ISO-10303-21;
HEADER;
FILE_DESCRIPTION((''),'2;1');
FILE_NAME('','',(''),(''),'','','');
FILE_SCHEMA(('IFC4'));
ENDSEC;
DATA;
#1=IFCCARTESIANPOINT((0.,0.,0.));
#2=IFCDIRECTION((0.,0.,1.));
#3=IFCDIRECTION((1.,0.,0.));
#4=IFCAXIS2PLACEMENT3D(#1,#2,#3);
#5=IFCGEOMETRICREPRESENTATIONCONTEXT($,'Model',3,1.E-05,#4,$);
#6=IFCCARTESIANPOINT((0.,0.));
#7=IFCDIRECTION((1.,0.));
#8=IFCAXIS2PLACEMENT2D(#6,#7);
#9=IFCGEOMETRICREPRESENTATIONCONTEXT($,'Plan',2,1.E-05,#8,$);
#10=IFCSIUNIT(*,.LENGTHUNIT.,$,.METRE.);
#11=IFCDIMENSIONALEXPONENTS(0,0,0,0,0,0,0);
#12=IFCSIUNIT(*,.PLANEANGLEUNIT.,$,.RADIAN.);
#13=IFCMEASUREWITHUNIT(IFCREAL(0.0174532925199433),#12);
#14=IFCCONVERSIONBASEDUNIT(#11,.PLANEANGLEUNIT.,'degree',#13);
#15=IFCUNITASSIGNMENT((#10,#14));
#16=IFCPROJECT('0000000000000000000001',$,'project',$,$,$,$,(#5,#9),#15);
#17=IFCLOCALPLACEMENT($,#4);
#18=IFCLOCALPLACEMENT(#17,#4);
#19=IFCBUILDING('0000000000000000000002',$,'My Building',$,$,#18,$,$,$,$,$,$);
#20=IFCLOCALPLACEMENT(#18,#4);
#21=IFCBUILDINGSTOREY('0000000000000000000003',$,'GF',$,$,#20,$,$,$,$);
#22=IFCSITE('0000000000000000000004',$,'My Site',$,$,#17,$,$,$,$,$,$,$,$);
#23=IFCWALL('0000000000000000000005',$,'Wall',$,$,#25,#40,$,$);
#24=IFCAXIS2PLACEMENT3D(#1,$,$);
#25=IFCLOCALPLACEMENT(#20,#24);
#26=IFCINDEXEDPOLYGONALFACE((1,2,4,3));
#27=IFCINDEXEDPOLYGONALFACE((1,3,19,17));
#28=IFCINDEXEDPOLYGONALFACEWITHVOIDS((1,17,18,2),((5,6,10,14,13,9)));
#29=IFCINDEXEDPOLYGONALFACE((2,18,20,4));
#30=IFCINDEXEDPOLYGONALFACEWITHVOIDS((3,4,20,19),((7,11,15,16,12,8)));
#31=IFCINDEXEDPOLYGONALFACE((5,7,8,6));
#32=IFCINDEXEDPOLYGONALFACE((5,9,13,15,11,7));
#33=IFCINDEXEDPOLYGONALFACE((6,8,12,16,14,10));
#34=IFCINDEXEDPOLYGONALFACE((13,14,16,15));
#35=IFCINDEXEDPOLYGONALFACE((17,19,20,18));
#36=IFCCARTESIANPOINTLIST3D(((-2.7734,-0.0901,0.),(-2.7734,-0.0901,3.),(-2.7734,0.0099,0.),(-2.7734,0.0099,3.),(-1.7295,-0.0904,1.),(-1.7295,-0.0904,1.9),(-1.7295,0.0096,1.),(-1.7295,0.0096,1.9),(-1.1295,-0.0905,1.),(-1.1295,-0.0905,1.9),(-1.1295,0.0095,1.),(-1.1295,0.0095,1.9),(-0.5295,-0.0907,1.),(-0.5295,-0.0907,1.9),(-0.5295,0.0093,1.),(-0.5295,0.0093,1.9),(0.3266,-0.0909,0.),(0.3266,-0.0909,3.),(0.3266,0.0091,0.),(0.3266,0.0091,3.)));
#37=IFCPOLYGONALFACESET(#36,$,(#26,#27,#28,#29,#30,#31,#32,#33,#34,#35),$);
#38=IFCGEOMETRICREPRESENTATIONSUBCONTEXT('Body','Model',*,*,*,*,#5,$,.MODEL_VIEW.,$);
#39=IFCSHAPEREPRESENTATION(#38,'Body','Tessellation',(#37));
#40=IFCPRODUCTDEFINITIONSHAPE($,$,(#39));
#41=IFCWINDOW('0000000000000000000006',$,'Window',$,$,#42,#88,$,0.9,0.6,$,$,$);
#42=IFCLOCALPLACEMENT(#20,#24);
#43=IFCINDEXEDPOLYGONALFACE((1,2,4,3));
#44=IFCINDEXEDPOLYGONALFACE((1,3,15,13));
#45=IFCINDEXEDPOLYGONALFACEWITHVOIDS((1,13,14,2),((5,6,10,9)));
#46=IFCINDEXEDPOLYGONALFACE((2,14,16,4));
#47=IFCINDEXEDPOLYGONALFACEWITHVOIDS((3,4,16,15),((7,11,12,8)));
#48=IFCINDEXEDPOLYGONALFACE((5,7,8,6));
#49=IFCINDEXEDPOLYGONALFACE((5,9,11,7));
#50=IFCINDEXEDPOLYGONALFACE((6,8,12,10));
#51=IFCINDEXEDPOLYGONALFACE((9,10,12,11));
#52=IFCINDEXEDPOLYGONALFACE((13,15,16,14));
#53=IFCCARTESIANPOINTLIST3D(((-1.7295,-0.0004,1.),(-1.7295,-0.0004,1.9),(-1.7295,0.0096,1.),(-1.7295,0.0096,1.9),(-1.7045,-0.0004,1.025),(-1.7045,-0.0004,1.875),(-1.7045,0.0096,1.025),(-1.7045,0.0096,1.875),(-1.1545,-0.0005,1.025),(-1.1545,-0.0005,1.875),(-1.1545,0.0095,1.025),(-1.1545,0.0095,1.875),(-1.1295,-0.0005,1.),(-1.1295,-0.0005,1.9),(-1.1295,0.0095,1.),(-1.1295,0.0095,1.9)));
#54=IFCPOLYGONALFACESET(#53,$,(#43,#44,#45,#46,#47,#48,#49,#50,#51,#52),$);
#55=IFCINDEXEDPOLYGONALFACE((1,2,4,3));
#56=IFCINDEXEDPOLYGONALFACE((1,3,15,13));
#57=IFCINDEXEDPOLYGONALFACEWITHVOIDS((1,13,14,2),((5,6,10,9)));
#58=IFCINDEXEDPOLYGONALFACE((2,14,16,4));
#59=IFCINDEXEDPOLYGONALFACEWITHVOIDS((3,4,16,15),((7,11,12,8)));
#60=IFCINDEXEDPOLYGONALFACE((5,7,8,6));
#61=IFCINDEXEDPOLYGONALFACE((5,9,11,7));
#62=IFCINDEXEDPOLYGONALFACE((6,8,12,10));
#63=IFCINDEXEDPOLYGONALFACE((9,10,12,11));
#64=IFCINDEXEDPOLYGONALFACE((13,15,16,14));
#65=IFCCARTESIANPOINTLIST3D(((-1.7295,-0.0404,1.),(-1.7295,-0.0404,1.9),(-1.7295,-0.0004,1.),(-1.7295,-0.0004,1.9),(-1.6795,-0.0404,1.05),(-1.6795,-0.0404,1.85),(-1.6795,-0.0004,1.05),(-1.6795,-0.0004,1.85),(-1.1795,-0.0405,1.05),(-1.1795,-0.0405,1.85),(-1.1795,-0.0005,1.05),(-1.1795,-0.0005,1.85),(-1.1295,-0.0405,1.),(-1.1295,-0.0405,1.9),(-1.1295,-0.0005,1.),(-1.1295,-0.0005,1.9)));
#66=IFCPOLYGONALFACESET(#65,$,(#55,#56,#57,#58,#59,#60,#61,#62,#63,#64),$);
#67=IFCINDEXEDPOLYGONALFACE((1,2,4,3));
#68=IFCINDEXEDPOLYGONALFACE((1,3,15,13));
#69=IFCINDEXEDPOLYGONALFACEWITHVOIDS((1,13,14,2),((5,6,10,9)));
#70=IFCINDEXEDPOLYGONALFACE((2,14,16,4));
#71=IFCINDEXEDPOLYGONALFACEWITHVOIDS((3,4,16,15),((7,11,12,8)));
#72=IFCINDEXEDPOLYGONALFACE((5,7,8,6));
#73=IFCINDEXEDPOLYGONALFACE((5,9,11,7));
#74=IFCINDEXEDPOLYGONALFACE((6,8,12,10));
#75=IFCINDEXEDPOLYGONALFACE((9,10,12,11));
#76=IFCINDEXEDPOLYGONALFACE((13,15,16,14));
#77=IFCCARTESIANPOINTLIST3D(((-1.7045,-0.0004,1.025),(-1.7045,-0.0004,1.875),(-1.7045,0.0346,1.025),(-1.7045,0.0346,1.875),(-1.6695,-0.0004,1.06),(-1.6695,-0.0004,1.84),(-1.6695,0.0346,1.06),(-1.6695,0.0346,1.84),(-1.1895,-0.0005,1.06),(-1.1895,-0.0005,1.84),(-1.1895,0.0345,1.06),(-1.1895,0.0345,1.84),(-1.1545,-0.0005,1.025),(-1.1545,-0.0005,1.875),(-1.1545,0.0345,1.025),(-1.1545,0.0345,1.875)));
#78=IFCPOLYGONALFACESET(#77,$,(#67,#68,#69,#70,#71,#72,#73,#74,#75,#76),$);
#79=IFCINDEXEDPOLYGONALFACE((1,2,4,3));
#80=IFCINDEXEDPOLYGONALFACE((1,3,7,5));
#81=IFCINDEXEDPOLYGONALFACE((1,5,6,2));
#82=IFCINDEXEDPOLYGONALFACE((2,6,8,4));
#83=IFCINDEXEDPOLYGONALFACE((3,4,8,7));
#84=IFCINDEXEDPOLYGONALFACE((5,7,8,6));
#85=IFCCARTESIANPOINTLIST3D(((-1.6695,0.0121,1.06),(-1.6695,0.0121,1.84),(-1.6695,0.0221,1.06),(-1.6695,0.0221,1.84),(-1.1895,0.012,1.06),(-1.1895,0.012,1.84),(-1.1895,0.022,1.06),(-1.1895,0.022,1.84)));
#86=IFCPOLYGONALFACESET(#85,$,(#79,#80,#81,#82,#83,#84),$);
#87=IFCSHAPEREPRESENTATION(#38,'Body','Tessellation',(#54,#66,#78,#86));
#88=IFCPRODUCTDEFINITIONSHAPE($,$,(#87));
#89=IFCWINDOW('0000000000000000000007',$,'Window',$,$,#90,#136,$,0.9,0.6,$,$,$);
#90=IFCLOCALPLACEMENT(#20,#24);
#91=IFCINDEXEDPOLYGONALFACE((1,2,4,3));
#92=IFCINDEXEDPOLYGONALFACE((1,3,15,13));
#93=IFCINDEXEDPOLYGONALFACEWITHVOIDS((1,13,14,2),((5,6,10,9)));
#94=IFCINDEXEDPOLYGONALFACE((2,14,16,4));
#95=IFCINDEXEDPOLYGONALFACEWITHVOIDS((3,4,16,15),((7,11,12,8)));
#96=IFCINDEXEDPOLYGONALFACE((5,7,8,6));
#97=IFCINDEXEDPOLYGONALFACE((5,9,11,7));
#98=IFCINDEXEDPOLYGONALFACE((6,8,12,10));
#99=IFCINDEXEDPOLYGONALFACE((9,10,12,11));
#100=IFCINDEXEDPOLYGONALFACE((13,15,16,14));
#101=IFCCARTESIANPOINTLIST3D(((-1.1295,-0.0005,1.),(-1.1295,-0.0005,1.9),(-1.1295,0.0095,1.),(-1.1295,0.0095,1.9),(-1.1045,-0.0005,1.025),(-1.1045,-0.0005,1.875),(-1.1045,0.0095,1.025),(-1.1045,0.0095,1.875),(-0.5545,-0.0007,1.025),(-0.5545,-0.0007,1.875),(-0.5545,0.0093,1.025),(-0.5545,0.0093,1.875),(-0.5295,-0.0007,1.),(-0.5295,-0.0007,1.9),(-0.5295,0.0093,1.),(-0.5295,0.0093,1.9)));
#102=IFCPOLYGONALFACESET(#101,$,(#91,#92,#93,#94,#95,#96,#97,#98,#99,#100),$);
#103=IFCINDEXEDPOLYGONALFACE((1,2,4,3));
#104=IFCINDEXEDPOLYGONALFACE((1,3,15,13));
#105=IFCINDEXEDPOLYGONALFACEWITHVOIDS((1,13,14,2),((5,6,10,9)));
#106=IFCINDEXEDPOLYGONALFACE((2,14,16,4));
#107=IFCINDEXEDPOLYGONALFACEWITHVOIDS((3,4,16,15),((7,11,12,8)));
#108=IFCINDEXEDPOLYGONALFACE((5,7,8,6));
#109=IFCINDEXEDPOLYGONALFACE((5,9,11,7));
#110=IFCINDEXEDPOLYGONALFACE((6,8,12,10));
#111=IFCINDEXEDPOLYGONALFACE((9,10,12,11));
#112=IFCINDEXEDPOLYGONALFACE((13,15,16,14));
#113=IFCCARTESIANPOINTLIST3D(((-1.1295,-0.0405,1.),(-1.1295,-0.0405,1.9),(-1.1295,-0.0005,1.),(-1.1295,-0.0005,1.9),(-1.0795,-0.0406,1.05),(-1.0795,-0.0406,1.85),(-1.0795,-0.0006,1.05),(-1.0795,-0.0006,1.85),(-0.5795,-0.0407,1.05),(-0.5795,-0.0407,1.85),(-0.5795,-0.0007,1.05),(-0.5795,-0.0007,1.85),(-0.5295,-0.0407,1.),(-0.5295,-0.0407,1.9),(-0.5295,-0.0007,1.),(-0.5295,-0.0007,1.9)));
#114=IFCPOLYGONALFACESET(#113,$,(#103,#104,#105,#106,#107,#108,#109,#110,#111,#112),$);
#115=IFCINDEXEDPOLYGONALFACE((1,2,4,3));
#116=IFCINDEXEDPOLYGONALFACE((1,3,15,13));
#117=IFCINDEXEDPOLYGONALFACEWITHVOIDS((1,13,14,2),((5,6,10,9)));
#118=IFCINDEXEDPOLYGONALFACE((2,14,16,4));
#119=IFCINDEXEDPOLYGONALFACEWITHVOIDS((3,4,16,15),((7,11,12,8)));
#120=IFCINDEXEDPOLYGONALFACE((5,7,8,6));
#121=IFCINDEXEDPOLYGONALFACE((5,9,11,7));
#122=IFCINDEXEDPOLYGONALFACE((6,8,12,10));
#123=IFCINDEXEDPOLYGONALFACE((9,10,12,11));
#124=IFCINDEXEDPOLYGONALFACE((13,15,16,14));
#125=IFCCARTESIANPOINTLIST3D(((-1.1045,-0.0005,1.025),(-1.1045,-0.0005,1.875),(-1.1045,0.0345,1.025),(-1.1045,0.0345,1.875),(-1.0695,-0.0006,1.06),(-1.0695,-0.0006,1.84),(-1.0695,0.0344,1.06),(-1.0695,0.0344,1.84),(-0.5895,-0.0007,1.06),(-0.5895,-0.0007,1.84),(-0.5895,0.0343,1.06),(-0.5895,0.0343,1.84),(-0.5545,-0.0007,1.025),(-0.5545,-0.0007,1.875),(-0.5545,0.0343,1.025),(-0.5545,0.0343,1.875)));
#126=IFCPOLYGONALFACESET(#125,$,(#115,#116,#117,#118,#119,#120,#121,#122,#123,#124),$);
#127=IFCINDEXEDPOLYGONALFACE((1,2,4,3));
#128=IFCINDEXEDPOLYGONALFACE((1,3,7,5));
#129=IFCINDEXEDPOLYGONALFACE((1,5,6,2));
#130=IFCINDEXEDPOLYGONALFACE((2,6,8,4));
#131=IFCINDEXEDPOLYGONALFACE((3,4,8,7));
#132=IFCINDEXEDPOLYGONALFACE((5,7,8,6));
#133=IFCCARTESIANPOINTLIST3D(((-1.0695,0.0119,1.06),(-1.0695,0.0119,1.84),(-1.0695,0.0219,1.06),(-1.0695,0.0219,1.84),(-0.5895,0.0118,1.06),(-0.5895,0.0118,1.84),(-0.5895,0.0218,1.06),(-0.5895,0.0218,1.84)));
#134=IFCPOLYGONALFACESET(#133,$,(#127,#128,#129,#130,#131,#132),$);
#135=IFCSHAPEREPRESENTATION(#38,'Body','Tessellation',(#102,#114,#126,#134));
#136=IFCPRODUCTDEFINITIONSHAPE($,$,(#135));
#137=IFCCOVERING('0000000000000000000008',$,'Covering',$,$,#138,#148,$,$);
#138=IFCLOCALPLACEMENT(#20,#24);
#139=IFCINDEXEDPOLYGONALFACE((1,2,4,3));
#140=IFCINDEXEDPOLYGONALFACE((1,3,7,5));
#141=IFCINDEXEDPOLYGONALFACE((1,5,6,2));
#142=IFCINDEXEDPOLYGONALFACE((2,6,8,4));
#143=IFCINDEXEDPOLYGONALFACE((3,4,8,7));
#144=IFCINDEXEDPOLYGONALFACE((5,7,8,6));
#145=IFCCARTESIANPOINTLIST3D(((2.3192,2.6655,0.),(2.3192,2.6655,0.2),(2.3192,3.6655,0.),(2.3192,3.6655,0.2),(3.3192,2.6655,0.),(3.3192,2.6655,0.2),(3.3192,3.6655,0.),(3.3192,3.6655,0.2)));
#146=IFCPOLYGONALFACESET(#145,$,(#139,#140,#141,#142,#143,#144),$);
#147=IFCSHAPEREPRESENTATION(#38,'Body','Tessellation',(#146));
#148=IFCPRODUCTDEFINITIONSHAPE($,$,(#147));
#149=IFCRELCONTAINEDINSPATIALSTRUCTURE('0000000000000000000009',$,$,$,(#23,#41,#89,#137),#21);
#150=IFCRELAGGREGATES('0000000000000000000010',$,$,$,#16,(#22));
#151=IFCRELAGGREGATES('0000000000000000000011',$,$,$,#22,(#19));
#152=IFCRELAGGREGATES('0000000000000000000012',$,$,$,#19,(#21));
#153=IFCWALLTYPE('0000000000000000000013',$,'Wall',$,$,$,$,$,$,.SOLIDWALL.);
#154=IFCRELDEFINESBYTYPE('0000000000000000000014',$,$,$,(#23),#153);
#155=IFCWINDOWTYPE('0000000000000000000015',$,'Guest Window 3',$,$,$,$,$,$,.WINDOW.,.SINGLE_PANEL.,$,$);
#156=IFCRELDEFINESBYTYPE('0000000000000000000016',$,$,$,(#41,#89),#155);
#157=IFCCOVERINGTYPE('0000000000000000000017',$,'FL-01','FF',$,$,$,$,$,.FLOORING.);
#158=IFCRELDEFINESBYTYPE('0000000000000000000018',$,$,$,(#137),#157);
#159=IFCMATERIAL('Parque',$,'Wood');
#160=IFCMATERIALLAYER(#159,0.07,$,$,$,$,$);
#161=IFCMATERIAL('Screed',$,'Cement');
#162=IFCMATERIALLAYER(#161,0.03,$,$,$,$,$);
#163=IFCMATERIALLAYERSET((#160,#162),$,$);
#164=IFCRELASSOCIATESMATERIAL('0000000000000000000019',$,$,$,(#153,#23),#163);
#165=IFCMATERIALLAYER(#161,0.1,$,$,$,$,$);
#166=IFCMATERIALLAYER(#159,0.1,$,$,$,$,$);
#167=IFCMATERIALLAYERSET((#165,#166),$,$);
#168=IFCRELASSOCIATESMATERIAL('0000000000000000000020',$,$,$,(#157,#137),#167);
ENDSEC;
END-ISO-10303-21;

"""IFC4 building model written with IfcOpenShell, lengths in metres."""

from ifc_helpers import new_model, entity, si_unit, converted_unit, frame, origin_with_axes, origin_2d_with_axis, place, context, subcontext, project, spatial, line, indexed_curve, outline, extrude, shape, source, transform, mapped, material, layer, layer_set, layer_usage, type_object, type_shapes, element, fill, save


model = new_model("IFC4")

# Units and contexts
model_context = context("Model", 3, precision=1e-05, world=origin_with_axes())
plan_context = context("Plan", 2, precision=1e-05, world=origin_2d_with_axis())
body_context_1 = subcontext(model_context, "Body", "Model", "MODEL_VIEW")
body_context_2 = subcontext(plan_context, "Body", "Plan", "PLAN_VIEW")
ifc_project = project(units=[si_unit("LENGTHUNIT", "METRE"), converted_unit("PLANEANGLEUNIT", "degree", entity("IfcReal", 0.0174532925199433), si_unit("PLANEANGLEUNIT", "RADIAN"), dimensions=[0, 0, 0, 0, 0, 0, 0])], contexts=[model_context, plan_context])

# Site, building, storey
site_placement = place(None, origin_with_axes())
site = spatial("IfcSite", under=ifc_project, at=site_placement, Name="My Site")
building_placement = place(site_placement, origin_with_axes())
building = spatial("IfcBuilding", under=site, at=building_placement, Name="My Building")
storey_placement = place(building_placement, origin_with_axes())
storey = spatial("IfcBuildingStorey", under=building, at=storey_placement, Name="GF")

# Shared definitions
ifc_material_1 = material(Name="Parque", Category="Wood")
ifc_layer_1 = layer(ifc_material_1, 0.07)
ifc_material_2 = material(Name="Screed", Category="Cement")
ifc_layer_2 = layer(ifc_material_2, 0.03)
ifc_layer_set_1 = layer_set([ifc_layer_1, ifc_layer_2])
wall_type = type_object("IfcWallType", Name="Wall", PredefinedType="SOLIDWALL", material=ifc_layer_set_1)

# Wall, openings, windows
ifc_layer_usage_1 = layer_usage(ifc_layer_set_1, "AXIS2", "POSITIVE", 0.0)
wall_1_placement = place(storey_placement, frame((-2.7734, -0.0901, 0.0), z_axis=(0.0, 0.0, 1.0), x_axis=(1.0, -0.000264, 0.0)))
wall_1 = element("IfcWall", 1, at=wall_1_placement, inside=storey, type_object=wall_type, material=ifc_layer_usage_1, Name="Wall", context=body_context_1, shape_type="SweptSolid", body=[
    extrude(outline(indexed_curve([(0.0, 0.0), (0.0, 0.1), (3.1, 0.1), (3.1, 0.0)], segments=[line(1, 2, 3, 4, 1)])), origin_with_axes(), (0.0, 0.0, 1.0), 3.0),
])
shared_shape_1 = source(origin_with_axes(), body_context_1, "Body", "SweptSolid", [
    extrude(outline(indexed_curve([(0.0, 0.0), (0.6, 0.0), (0.6, 0.9), (0.0, 0.9)], segments=[line(1, 2, 3, 4, 1)])), frame((0.0, -0.6, 0.0), z_axis=(0.0, -1.0, 0.0), x_axis=(1.0, 0.0, 0.0)), (0.0, 0.0, -1.0), 1.2),
])
opening_1_placement = place(wall_1_placement, frame((1.0439, 0.0, 1.0), z_axis=(0.0, 0.0, 1.0), x_axis=(1.0, 0.0, 0.0)))
opening_1 = element("IfcOpeningElement", 2, at=opening_1_placement, cuts=wall_1, PredefinedType="OPENING", context=body_context_1, shape_type="MappedRepresentation", body=[
    mapped(shared_shape_1, transform((0.0, 0.0, 0.0), x_axis=(1.0, 0.0, 0.0), y_axis=(0.0, 1.0, 0.0), z_axis=(0.0, 0.0, 1.0), scale=1.0)),
])
opening_2_placement = place(wall_1_placement, frame((1.6439, 0.0, 1.0), z_axis=(0.0, 0.0, 1.0), x_axis=(1.0, 0.0, 0.0)))
opening_2 = element("IfcOpeningElement", 3, at=opening_2_placement, cuts=wall_1, PredefinedType="OPENING", context=body_context_1, shape_type="MappedRepresentation", body=[
    mapped(shared_shape_1, transform((0.0, 0.0, 0.0), x_axis=(1.0, 0.0, 0.0), y_axis=(0.0, 1.0, 0.0), z_axis=(0.0, 0.0, 1.0), scale=1.0)),
])
window_type_1 = type_object("IfcWindowType", Name="Guest Window 3", PartitioningType="SINGLE_PANEL", PredefinedType="WINDOW")
shared_shape_2 = source(origin_with_axes(), body_context_1, "Body", "SweptSolid", [
    extrude(outline(indexed_curve([(0.0, 0.0), (0.6, 0.0), (0.6, 0.9), (0.0, 0.9)], segments=[line(1, 2, 3, 4, 1)]), holes=[indexed_curve([(0.025, 0.025), (0.575, 0.025), (0.575, 0.875), (0.025, 0.875)], segments=[line(1, 2, 3, 4, 1)])]), frame((0.0, 0.09, 0.0), z_axis=(0.0, -1.0, 0.0), x_axis=(1.0, 0.0, 0.0)), (0.0, 0.0, -1.0), 0.01),
    extrude(outline(indexed_curve([(0.0, 0.0), (0.6, 0.0), (0.6, 0.9), (0.0, 0.9)], segments=[line(1, 2, 3, 4, 1)]), holes=[indexed_curve([(0.05, 0.05), (0.55, 0.05), (0.55, 0.85), (0.05, 0.85)], segments=[line(1, 2, 3, 4, 1)])]), frame((0.0, 0.05, 0.0), z_axis=(0.0, -1.0, 0.0), x_axis=(1.0, 0.0, 0.0)), (0.0, 0.0, -1.0), 0.04),
    extrude(outline(indexed_curve([(0.0, 0.0), (0.55, 0.0), (0.55, 0.85), (0.0, 0.85)], segments=[line(1, 2, 3, 4, 1)]), holes=[indexed_curve([(0.035, 0.035), (0.515, 0.035), (0.515, 0.815), (0.035, 0.815)], segments=[line(1, 2, 3, 4, 1)])]), frame((0.025, 0.09, 0.025), z_axis=(0.0, -1.0, 0.0), x_axis=(1.0, 0.0, 0.0)), (0.0, 0.0, -1.0), 0.035),
    extrude(outline(indexed_curve([(0.035, 0.035), (0.515, 0.035), (0.515, 0.815), (0.035, 0.815)], segments=[line(1, 2, 3, 4, 1)])), frame((0.025, 0.1025, 0.025), z_axis=(0.0, -1.0, 0.0), x_axis=(1.0, 0.0, 0.0)), (0.0, 0.0, -1.0), 0.01),
])
shared_shape_3 = source(origin_with_axes(), body_context_2, "Body", "Curve2D", [
    entity("IfcIndexedPolyCurve", entity("IfcCartesianPointList2D", [[0.05, 0.05], [0.55, 0.05]])),
    entity("IfcIndexedPolyCurve", entity("IfcCartesianPointList2D", [[0.0, 0.1], [0.025, 0.1], [0.025, 0.09], [0.05, 0.09], [0.05, 0.05], [0.0, 0.05]]), [entity("IfcLineIndex", [1, 2, 3, 4, 5, 6, 1])]),
    entity("IfcIndexedPolyCurve", entity("IfcCartesianPointList2D", [[0.6, 0.1], [0.575, 0.1], [0.575, 0.09], [0.55, 0.09], [0.55, 0.05], [0.6, 0.05]]), [entity("IfcLineIndex", [1, 2, 3, 4, 5, 6, 1])]),
    entity("IfcIndexedPolyCurve", entity("IfcCartesianPointList2D", [[0.025, 0.09], [0.06, 0.09], [0.06, 0.125], [0.025, 0.125]]), [entity("IfcLineIndex", [1, 2, 3, 4, 1])]),
    entity("IfcIndexedPolyCurve", entity("IfcCartesianPointList2D", [[0.575, 0.09], [0.54, 0.09], [0.54, 0.125], [0.575, 0.125]]), [entity("IfcLineIndex", [1, 2, 3, 4, 1])]),
    entity("IfcIndexedPolyCurve", entity("IfcCartesianPointList2D", [[0.06, 0.09], [0.54, 0.09]])),
    entity("IfcIndexedPolyCurve", entity("IfcCartesianPointList2D", [[0.06, 0.125], [0.54, 0.125]])),
    entity("IfcIndexedPolyCurve", entity("IfcCartesianPointList2D", [[0.06, 0.1075], [0.54, 0.1075]])),
])
type_shapes(window_type_1, [shared_shape_2, shared_shape_3])
window_1_placement = place(opening_1_placement, frame((0.0, 0.0, 0.0), z_axis=(0.0, 0.0, 1.0), x_axis=(1.0, 0.0, 0.0)))
window_1 = element("IfcWindow", 4, at=window_1_placement, inside=storey, type_object=window_type_1, Name="Window", OverallHeight=0.9, OverallWidth=0.6, shapes=[
    shape(body_context_1, "Body", "MappedRepresentation", [mapped(shared_shape_2, transform((0.0, 0.0, 0.0), x_axis=(1.0, 0.0, 0.0), y_axis=(0.0, 1.0, 0.0), z_axis=(0.0, 0.0, 1.0), scale=1.0))]),
    shape(body_context_2, "Body", "MappedRepresentation", [mapped(shared_shape_3, transform((0.0, 0.0, 0.0), x_axis=(1.0, 0.0, 0.0), y_axis=(0.0, 1.0, 0.0), z_axis=(0.0, 0.0, 1.0), scale=1.0))]),
])
fill(opening_1, window_1)
window_2_placement = place(opening_2_placement, frame((0.0, 0.0, 0.0), z_axis=(0.0, 0.0, 1.0), x_axis=(1.0, 0.0, 0.0)))
window_2 = element("IfcWindow", 5, at=window_2_placement, inside=storey, type_object=window_type_1, Name="Window", OverallHeight=0.9, OverallWidth=0.6, shapes=[
    shape(body_context_1, "Body", "MappedRepresentation", [mapped(shared_shape_2, transform((0.0, 0.0, 0.0), x_axis=(1.0, 0.0, 0.0), y_axis=(0.0, 1.0, 0.0), z_axis=(0.0, 0.0, 1.0), scale=1.0))]),
    shape(body_context_2, "Body", "MappedRepresentation", [mapped(shared_shape_3, transform((0.0, 0.0, 0.0), x_axis=(1.0, 0.0, 0.0), y_axis=(0.0, 1.0, 0.0), z_axis=(0.0, 0.0, 1.0), scale=1.0))]),
])
fill(opening_2, window_2)

# Covering
ifc_layer_3 = layer(ifc_material_2, 0.1)
ifc_layer_4 = layer(ifc_material_1, 0.1)
ifc_layer_set_2 = layer_set([ifc_layer_3, ifc_layer_4])
ifc_layer_usage_2 = layer_usage(ifc_layer_set_2, "AXIS3", "POSITIVE", 0.0)
covering_type = type_object("IfcCoveringType", Name="FL-01", Description="FF", PredefinedType="FLOORING", material=ifc_layer_set_2)
covering_1_placement = place(storey_placement, frame((2.3192, 2.6655, 0.0), z_axis=(0.0, 0.0, 1.0), x_axis=(1.0, 0.0, 0.0)))
element("IfcCovering", 6, at=covering_1_placement, inside=storey, type_object=covering_type, material=ifc_layer_usage_2, Name="Covering", context=body_context_1, shape_type="SweptSolid", body=[
    extrude(outline(indexed_curve([(0.0, 0.0), (1.0, 0.0), (1.0, 1.0), (0.0, 1.0), (0.0, 0.0)])), None, (0.0, 0.0, 1.0), 0.2),
])

save(model, "model.ifc")
